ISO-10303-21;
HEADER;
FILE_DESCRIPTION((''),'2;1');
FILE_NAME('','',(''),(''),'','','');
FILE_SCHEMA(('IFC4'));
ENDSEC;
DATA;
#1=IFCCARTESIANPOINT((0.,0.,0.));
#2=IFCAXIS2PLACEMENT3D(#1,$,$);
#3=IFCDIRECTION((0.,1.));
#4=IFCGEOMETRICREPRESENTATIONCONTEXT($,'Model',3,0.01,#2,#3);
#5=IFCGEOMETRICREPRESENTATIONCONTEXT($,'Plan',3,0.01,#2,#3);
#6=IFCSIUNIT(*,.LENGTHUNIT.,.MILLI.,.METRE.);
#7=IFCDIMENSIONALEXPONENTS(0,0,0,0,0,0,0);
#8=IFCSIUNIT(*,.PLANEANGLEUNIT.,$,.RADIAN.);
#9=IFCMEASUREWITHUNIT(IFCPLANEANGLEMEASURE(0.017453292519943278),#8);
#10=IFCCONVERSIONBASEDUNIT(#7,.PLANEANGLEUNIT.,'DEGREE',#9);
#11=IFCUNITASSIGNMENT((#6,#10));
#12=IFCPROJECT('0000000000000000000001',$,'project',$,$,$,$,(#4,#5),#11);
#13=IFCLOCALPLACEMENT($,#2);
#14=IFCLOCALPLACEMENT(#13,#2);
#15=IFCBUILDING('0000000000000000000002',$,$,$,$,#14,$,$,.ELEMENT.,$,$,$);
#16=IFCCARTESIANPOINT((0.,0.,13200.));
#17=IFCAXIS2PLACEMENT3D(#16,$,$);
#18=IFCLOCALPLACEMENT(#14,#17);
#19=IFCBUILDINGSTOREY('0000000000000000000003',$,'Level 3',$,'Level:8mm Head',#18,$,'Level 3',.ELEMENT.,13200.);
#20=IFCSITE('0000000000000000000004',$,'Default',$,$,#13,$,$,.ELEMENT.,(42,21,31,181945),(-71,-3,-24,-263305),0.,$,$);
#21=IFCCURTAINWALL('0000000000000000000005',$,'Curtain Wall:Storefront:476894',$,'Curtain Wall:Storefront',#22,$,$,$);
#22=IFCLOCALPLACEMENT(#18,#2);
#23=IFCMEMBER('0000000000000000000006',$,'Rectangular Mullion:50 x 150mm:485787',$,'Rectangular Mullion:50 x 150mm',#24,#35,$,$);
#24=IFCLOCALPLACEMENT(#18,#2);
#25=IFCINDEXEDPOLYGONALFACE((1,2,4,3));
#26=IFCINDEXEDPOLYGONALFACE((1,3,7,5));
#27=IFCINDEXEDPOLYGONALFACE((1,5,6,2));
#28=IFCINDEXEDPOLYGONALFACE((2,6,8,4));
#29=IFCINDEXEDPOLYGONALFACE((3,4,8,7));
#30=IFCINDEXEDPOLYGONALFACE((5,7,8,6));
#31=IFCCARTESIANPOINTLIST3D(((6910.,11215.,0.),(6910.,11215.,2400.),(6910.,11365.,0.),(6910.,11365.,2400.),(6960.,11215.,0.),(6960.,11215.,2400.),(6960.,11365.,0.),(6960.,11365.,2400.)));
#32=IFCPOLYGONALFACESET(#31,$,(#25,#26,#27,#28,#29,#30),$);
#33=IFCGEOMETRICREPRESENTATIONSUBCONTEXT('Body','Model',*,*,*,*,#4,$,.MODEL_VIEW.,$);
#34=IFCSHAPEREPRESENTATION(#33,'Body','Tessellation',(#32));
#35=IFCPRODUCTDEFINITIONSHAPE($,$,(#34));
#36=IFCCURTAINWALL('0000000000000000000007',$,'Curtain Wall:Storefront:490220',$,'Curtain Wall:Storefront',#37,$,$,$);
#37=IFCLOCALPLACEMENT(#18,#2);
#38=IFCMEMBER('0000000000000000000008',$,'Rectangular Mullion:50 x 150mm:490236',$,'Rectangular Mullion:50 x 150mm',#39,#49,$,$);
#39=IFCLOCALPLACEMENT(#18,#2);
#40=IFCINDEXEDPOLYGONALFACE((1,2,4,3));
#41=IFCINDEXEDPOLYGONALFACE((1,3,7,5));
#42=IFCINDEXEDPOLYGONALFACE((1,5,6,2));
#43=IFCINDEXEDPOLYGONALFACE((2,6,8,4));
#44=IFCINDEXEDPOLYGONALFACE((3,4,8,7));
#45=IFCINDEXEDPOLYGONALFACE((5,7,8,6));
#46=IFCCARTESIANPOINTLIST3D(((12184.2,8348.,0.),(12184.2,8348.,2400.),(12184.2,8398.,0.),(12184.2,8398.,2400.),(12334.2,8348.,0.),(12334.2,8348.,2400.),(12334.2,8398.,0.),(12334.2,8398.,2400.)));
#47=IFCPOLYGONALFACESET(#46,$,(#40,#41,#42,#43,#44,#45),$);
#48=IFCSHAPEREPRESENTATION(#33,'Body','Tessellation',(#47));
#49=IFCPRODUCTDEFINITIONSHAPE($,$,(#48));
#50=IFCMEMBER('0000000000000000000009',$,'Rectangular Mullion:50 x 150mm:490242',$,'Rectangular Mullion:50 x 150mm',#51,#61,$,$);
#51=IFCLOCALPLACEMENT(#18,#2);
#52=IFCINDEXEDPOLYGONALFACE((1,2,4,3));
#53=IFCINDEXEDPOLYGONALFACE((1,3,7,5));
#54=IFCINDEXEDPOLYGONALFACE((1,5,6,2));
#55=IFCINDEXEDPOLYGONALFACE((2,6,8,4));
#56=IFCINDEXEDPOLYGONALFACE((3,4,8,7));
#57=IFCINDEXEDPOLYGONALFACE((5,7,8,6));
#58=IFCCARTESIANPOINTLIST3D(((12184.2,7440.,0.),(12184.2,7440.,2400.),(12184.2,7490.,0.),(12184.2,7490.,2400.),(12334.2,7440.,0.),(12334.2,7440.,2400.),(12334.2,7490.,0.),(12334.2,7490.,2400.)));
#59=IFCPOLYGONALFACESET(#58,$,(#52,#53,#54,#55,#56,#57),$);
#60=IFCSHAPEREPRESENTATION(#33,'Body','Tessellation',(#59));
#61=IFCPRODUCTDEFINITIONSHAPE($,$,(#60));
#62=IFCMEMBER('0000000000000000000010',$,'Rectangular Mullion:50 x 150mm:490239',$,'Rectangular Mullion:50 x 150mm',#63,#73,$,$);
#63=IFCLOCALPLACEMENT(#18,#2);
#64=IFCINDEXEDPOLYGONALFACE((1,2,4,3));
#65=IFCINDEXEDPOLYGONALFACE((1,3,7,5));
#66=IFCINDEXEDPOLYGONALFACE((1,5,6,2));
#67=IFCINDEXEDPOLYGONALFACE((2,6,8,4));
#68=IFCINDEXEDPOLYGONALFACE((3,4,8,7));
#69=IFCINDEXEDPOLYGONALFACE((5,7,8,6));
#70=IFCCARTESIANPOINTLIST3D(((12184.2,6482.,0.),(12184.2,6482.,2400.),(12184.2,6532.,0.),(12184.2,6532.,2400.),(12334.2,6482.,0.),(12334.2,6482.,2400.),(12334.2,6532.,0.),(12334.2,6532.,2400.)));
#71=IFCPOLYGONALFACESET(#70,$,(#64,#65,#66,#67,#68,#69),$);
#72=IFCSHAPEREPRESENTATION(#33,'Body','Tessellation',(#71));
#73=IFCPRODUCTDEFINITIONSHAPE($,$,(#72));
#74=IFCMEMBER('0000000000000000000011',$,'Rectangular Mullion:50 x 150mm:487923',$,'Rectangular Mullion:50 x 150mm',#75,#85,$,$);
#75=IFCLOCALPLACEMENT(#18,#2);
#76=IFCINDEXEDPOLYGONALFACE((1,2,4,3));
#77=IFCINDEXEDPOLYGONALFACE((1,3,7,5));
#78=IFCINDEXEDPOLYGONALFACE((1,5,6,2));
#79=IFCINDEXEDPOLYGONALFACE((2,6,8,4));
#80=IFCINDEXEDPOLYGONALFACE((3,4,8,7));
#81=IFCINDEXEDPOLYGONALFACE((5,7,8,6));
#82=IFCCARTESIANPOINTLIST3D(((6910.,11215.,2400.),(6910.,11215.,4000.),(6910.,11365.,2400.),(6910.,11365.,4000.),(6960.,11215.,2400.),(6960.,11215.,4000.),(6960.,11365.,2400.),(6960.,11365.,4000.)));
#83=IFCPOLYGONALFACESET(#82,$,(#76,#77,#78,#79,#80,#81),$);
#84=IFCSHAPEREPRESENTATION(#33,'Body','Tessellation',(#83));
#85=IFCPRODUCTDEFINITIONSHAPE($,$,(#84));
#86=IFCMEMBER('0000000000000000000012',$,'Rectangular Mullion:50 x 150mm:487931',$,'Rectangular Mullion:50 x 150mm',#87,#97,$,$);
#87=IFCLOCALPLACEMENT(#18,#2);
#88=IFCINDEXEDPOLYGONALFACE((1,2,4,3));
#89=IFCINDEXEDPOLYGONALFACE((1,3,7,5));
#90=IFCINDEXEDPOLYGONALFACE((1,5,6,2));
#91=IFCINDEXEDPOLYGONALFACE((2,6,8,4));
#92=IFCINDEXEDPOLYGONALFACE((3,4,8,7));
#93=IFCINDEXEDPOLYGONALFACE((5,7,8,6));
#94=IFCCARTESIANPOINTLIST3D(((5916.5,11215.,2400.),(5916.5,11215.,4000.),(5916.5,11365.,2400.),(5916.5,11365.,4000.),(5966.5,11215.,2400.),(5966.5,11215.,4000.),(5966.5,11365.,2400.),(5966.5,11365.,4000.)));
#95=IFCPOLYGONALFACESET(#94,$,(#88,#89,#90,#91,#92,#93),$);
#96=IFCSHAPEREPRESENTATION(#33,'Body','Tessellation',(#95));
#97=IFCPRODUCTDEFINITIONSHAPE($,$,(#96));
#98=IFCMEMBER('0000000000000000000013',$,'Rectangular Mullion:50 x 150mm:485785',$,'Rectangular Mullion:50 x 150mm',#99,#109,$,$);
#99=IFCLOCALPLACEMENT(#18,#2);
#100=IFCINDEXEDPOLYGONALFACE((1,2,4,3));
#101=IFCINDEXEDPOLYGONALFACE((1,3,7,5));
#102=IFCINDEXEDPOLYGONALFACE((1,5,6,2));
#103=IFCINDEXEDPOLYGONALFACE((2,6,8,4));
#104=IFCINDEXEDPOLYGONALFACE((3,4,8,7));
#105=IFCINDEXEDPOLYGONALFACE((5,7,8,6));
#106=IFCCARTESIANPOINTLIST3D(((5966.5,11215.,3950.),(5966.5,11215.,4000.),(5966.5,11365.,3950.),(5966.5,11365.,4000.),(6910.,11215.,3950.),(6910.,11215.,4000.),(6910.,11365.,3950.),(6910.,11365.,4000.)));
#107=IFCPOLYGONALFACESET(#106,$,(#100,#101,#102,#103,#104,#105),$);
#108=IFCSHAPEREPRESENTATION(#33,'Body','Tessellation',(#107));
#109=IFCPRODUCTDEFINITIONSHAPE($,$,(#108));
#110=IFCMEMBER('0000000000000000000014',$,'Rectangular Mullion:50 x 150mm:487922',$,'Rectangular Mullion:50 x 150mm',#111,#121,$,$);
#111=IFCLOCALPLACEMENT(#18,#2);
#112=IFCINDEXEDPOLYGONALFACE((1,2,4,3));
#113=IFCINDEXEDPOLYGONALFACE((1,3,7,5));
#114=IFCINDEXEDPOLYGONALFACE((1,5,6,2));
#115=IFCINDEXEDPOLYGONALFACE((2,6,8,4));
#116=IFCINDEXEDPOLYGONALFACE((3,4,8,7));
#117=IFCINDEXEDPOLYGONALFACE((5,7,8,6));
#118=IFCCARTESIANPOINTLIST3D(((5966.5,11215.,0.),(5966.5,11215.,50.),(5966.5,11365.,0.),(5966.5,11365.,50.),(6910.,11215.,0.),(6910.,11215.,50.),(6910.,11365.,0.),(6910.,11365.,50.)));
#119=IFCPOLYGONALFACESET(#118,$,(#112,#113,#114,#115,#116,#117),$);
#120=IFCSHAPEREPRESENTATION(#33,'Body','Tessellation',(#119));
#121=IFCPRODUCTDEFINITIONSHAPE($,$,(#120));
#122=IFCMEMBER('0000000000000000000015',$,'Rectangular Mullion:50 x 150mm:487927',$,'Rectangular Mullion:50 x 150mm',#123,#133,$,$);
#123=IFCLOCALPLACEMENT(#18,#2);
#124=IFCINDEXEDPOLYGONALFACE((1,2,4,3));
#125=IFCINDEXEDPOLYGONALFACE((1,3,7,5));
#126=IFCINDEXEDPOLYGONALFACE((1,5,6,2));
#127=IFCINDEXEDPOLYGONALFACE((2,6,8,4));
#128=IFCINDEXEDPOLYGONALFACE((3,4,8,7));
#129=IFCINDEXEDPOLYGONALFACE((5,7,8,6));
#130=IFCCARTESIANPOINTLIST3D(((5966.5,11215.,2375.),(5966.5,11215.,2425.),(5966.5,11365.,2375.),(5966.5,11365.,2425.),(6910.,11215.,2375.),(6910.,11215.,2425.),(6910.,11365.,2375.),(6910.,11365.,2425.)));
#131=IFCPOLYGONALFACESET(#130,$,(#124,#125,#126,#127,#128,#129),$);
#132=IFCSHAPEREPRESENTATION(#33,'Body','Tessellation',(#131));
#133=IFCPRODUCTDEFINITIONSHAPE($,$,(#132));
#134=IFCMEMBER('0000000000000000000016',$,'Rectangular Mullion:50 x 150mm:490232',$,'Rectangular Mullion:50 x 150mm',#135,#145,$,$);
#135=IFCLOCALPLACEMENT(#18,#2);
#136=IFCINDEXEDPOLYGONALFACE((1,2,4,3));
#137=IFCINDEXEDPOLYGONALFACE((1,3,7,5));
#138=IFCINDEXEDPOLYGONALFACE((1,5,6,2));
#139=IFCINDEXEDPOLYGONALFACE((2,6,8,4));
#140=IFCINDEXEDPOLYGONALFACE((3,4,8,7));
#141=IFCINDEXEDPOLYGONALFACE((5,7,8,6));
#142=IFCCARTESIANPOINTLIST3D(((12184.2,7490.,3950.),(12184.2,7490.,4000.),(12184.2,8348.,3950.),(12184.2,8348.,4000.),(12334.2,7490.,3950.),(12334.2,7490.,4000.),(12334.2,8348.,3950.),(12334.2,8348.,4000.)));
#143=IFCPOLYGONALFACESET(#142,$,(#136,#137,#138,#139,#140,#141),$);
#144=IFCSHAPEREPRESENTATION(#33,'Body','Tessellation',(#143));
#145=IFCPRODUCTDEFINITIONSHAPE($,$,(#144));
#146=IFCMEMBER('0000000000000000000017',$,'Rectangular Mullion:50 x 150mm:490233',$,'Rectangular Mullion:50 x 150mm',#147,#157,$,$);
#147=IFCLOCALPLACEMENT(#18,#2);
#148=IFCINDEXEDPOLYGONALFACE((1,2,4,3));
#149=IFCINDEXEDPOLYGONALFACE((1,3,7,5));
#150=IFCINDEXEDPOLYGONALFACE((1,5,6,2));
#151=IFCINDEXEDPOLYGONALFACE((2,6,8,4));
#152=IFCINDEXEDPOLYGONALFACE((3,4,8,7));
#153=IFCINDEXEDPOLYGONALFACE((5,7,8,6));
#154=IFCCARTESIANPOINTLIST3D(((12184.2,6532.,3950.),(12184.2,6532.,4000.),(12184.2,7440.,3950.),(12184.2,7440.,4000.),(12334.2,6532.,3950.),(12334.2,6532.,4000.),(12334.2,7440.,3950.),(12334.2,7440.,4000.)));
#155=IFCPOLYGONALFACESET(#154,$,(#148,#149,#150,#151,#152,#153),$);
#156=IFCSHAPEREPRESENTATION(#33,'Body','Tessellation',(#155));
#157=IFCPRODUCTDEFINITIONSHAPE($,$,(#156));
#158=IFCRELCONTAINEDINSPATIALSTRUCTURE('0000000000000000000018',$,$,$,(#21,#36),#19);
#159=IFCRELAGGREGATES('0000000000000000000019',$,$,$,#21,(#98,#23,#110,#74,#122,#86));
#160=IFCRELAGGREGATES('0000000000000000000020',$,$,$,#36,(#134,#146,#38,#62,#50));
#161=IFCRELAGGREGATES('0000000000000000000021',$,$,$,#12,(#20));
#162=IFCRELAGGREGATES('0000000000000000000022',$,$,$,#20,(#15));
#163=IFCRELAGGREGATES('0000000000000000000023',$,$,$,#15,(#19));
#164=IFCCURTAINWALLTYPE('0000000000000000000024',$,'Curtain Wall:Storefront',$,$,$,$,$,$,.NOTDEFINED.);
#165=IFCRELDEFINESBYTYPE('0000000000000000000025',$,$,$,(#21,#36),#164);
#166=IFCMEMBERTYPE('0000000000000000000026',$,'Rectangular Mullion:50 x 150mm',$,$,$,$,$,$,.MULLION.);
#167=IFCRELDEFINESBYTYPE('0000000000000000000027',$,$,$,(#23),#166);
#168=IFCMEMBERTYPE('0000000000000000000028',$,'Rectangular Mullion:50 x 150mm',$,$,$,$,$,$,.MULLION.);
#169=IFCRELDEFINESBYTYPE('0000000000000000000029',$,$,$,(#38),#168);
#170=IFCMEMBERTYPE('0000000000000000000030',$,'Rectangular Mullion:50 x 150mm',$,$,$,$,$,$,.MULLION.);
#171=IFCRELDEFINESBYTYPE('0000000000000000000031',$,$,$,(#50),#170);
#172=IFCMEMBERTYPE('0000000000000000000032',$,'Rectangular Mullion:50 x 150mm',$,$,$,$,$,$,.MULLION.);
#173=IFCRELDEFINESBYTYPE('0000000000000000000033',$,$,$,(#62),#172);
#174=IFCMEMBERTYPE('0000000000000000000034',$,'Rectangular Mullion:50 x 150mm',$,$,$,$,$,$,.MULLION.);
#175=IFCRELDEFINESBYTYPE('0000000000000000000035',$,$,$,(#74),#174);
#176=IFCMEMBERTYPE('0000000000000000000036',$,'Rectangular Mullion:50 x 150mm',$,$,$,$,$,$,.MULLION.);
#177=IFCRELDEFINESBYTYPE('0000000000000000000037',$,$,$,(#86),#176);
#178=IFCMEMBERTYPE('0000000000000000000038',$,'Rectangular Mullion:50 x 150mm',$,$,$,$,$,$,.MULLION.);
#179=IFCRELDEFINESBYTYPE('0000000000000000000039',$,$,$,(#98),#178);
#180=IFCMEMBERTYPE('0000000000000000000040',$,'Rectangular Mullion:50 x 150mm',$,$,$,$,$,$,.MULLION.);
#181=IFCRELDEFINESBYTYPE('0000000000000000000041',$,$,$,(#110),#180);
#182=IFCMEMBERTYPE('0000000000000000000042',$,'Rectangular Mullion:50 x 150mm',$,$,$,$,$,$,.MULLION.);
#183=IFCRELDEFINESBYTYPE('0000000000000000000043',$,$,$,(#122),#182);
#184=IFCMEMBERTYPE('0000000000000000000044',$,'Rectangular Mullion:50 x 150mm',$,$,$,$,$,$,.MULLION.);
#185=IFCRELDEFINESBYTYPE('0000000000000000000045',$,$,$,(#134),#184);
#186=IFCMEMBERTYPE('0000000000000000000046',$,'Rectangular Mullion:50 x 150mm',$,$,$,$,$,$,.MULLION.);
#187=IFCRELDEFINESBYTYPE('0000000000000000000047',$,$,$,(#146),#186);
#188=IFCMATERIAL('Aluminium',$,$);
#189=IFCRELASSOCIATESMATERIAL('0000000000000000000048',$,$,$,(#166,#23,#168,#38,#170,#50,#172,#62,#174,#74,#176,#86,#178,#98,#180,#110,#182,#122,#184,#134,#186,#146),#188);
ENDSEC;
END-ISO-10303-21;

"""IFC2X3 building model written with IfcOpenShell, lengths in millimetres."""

from ifc_helpers import new_model, entity, si_unit, converted_unit, direction, frame, origin, origin_2d_with_axis, place, context, subcontext, project, spatial, rectangle, extrude, source, transform, mapped, material, type_object, type_shapes, element, aggregate, save


model = new_model("IFC2X3")

# Units and contexts
model_context = context("Model", 3, precision=0.01, world=origin(), true_north=direction((0.0, 1.0)))
plan_context = context("Plan", 3, precision=0.01, world=origin(), true_north=direction((0.0, 1.0)))
body_context = subcontext(model_context, "Body", "Model", "MODEL_VIEW")
ifc_project = project(units=[si_unit("LENGTHUNIT", "METRE", prefix="MILLI"), converted_unit("PLANEANGLEUNIT", "DEGREE", entity("IfcPlaneAngleMeasure", 0.017453292519943278), si_unit("PLANEANGLEUNIT", "RADIAN"), dimensions=[0, 0, 0, 0, 0, 0, 0])], contexts=[model_context, plan_context])

# Site, building, storey
site_placement = place(None, origin())
site = spatial("IfcSite", under=ifc_project, at=site_placement, Name="Default", CompositionType="ELEMENT", RefLatitude=(42, 21, 31, 181945), RefLongitude=(-71, -3, -24, -263305), RefElevation=0.0)
building_placement = place(site_placement, origin())
building = spatial("IfcBuilding", under=site, at=building_placement, CompositionType="ELEMENT")
storey_placement = place(building_placement, frame((0.0, 0.0, 13200.0)))
storey = spatial("IfcBuildingStorey", under=building, at=storey_placement, Name="Level 3", ObjectType="Level:8mm Head", LongName="Level 3", CompositionType="ELEMENT", Elevation=13200.0)

# Curtain wall, member
curtain_wall_type = type_object("IfcCurtainWallType", Name="Curtain Wall:Storefront", PredefinedType="NOTDEFINED")
curtain_wall_1_placement = place(storey_placement, frame((0.0, 0.0, -13200.0)))
curtain_wall_1 = element("IfcCurtainWall", 1, at=curtain_wall_1_placement, inside=storey, type_object=curtain_wall_type, Name="Curtain Wall:Storefront:476894", ObjectType="Curtain Wall:Storefront")
ifc_material_1 = material(Name="Aluminium")
member_type_1 = type_object("IfcMemberType", Name="Rectangular Mullion:50 x 150mm", PredefinedType="MULLION", material=ifc_material_1)
shared_shape_1 = source(origin(), body_context, "Body", "SweptSolid", [
    extrude(rectangle(XDim=50.0, YDim=150.0, at=origin_2d_with_axis()), frame((-25.0, 0.0, -2400.0), z_axis=(0.0, 0.0, 1.0), x_axis=(-1.0, 0.0, 0.0)), (0.0, 0.0, 1.0), 2400.0),
])
type_shapes(member_type_1, [shared_shape_1])
member_1_placement = place(curtain_wall_1_placement, frame((6960.0, 11290.0, 13200.0), z_axis=(0.0, 0.0, -1.0), x_axis=(1.0, 0.0, 0.0)))
member_1 = element("IfcMember", 2, at=member_1_placement, type_object=member_type_1, material=ifc_material_1, Name="Rectangular Mullion:50 x 150mm:485787", ObjectType="Rectangular Mullion:50 x 150mm", context=body_context, shape_type="MappedRepresentation", body=[
    mapped(shared_shape_1, transform((0.0, 0.0, 0.0), scale=1.0)),
])

# Curtain wall, members
curtain_wall_2_placement = place(storey_placement, frame((0.0, 0.0, -13200.0)))
curtain_wall_2 = element("IfcCurtainWall", 3, at=curtain_wall_2_placement, inside=storey, type_object=curtain_wall_type, Name="Curtain Wall:Storefront:490220", ObjectType="Curtain Wall:Storefront")
member_type_2 = type_object("IfcMemberType", Name="Rectangular Mullion:50 x 150mm", PredefinedType="MULLION", material=ifc_material_1)
shared_shape_2 = source(origin(), body_context, "Body", "SweptSolid", [
    extrude(rectangle(XDim=50.0, YDim=150.0, at=origin_2d_with_axis()), frame((-25.0, 0.0, -2400.0), z_axis=(0.0, 0.0, 1.0), x_axis=(-1.0, 0.0, 0.0)), (0.0, 0.0, 1.0), 2400.0),
])
type_shapes(member_type_2, [shared_shape_2])
member_2_placement = place(curtain_wall_2_placement, frame((12259.2, 8398.0, 13200.0), z_axis=(0.0, 0.0, -1.0), x_axis=(0.0, 1.0, 0.0)))
member_2 = element("IfcMember", 4, at=member_2_placement, type_object=member_type_2, material=ifc_material_1, Name="Rectangular Mullion:50 x 150mm:490236", ObjectType="Rectangular Mullion:50 x 150mm", context=body_context, shape_type="MappedRepresentation", body=[
    mapped(shared_shape_2, transform((0.0, 0.0, 0.0), scale=1.0)),
])
member_type_3 = type_object("IfcMemberType", Name="Rectangular Mullion:50 x 150mm", PredefinedType="MULLION", material=ifc_material_1)
shared_shape_3 = source(origin(), body_context, "Body", "SweptSolid", [
    extrude(rectangle(XDim=50.0, YDim=150.0, at=origin_2d_with_axis()), frame((0.0, 0.0, -2400.0), z_axis=(0.0, 0.0, 1.0), x_axis=(-1.0, 0.0, 0.0)), (0.0, 0.0, 1.0), 2400.0),
])
type_shapes(member_type_3, [shared_shape_3])
member_3_placement = place(curtain_wall_2_placement, frame((12259.2, 7465.0, 13200.0), z_axis=(0.0, 0.0, -1.0), x_axis=(0.0, 1.0, 0.0)))
member_3 = element("IfcMember", 5, at=member_3_placement, type_object=member_type_3, material=ifc_material_1, Name="Rectangular Mullion:50 x 150mm:490242", ObjectType="Rectangular Mullion:50 x 150mm", context=body_context, shape_type="MappedRepresentation", body=[
    mapped(shared_shape_3, transform((0.0, 0.0, 0.0), scale=1.0)),
])
member_type_4 = type_object("IfcMemberType", Name="Rectangular Mullion:50 x 150mm", PredefinedType="MULLION", material=ifc_material_1)
shared_shape_4 = source(origin(), body_context, "Body", "SweptSolid", [
    extrude(rectangle(XDim=50.0, YDim=150.0, at=origin_2d_with_axis()), frame((-25.0, 0.0, -2400.0), z_axis=(0.0, 0.0, 1.0), x_axis=(-1.0, 0.0, 0.0)), (0.0, 0.0, 1.0), 2400.0),
])
type_shapes(member_type_4, [shared_shape_4])
member_4_placement = place(curtain_wall_2_placement, frame((12259.2, 6482.0, 15600.0), z_axis=(0.0, 0.0, 1.0), x_axis=(0.0, -1.0, 0.0)))
member_4 = element("IfcMember", 6, at=member_4_placement, type_object=member_type_4, material=ifc_material_1, Name="Rectangular Mullion:50 x 150mm:490239", ObjectType="Rectangular Mullion:50 x 150mm", context=body_context, shape_type="MappedRepresentation", body=[
    mapped(shared_shape_4, transform((0.0, 0.0, 0.0), scale=1.0)),
])

# Members
member_type_5 = type_object("IfcMemberType", Name="Rectangular Mullion:50 x 150mm", PredefinedType="MULLION", material=ifc_material_1)
shared_shape_5 = source(origin(), body_context, "Body", "SweptSolid", [
    extrude(rectangle(XDim=50.0, YDim=150.0, at=origin_2d_with_axis()), frame((-25.0, 0.0, -1600.0), z_axis=(0.0, 0.0, 1.0), x_axis=(-1.0, 0.0, 0.0)), (0.0, 0.0, 1.0), 1600.0),
])
type_shapes(member_type_5, [shared_shape_5])
member_5_placement = place(curtain_wall_1_placement, frame((6960.0, 11290.0, 15600.0), z_axis=(0.0, 0.0, -1.0), x_axis=(1.0, 0.0, 0.0)))
member_5 = element("IfcMember", 7, at=member_5_placement, type_object=member_type_5, material=ifc_material_1, Name="Rectangular Mullion:50 x 150mm:487923", ObjectType="Rectangular Mullion:50 x 150mm", context=body_context, shape_type="MappedRepresentation", body=[
    mapped(shared_shape_5, transform((0.0, 0.0, 0.0), scale=1.0)),
])
member_type_6 = type_object("IfcMemberType", Name="Rectangular Mullion:50 x 150mm", PredefinedType="MULLION", material=ifc_material_1)
shared_shape_6 = source(origin(), body_context, "Body", "SweptSolid", [
    extrude(rectangle(XDim=50.0, YDim=150.0, at=origin_2d_with_axis()), frame((0.0, 0.0, -1600.0), z_axis=(0.0, 0.0, 1.0), x_axis=(-1.0, 0.0, 0.0)), (0.0, 0.0, 1.0), 1600.0),
])
type_shapes(member_type_6, [shared_shape_6])
member_6_placement = place(curtain_wall_1_placement, frame((5941.5, 11290.0, 15600.0), z_axis=(0.0, 0.0, -1.0), x_axis=(1.0, 0.0, 0.0)))
member_6 = element("IfcMember", 8, at=member_6_placement, type_object=member_type_6, material=ifc_material_1, Name="Rectangular Mullion:50 x 150mm:487931", ObjectType="Rectangular Mullion:50 x 150mm", context=body_context, shape_type="MappedRepresentation", body=[
    mapped(shared_shape_6, transform((0.0, 0.0, 0.0), scale=1.0)),
])
member_type_7 = type_object("IfcMemberType", Name="Rectangular Mullion:50 x 150mm", PredefinedType="MULLION", material=ifc_material_1)
shared_shape_7 = source(origin(), body_context, "Body", "SweptSolid", [
    extrude(rectangle(XDim=50.0, YDim=150.0, at=origin_2d_with_axis()), frame((-25.0, 0.0, -943.5), z_axis=(0.0, 0.0, 1.0), x_axis=(-1.0, 0.0, 0.0)), (0.0, 0.0, 1.0), 943.5),
])
type_shapes(member_type_7, [shared_shape_7])
member_7_placement = place(curtain_wall_1_placement, frame((6910.0, 11290.0, 17200.0), z_axis=(1.0, 0.0, 0.0), x_axis=(0.0, 0.0, 1.0)))
member_7 = element("IfcMember", 9, at=member_7_placement, type_object=member_type_7, material=ifc_material_1, Name="Rectangular Mullion:50 x 150mm:485785", ObjectType="Rectangular Mullion:50 x 150mm", context=body_context, shape_type="MappedRepresentation", body=[
    mapped(shared_shape_7, transform((0.0, 0.0, 0.0), scale=1.0)),
])
member_type_8 = type_object("IfcMemberType", Name="Rectangular Mullion:50 x 150mm", PredefinedType="MULLION", material=ifc_material_1)
shared_shape_8 = source(origin(), body_context, "Body", "SweptSolid", [
    extrude(rectangle(XDim=50.0, YDim=150.0, at=origin_2d_with_axis()), frame((-25.0, 0.0, -943.5), z_axis=(0.0, 0.0, 1.0), x_axis=(-1.0, 0.0, 0.0)), (0.0, 0.0, 1.0), 943.5),
])
type_shapes(member_type_8, [shared_shape_8])
member_8_placement = place(curtain_wall_1_placement, frame((5966.5, 11290.0, 13200.0), z_axis=(-1.0, 0.0, 0.0), x_axis=(0.0, 0.0, -1.0)))
member_8 = element("IfcMember", 10, at=member_8_placement, type_object=member_type_8, material=ifc_material_1, Name="Rectangular Mullion:50 x 150mm:487922", ObjectType="Rectangular Mullion:50 x 150mm", context=body_context, shape_type="MappedRepresentation", body=[
    mapped(shared_shape_8, transform((0.0, 0.0, 0.0), scale=1.0)),
])
member_type_9 = type_object("IfcMemberType", Name="Rectangular Mullion:50 x 150mm", PredefinedType="MULLION", material=ifc_material_1)
shared_shape_9 = source(origin(), body_context, "Body", "SweptSolid", [
    extrude(rectangle(XDim=50.0, YDim=150.0, at=origin_2d_with_axis()), frame((0.0, 0.0, -943.5), z_axis=(0.0, 0.0, 1.0), x_axis=(-1.0, 0.0, 0.0)), (0.0, 0.0, 1.0), 943.5),
])
type_shapes(member_type_9, [shared_shape_9])
member_9_placement = place(curtain_wall_1_placement, frame((6910.0, 11290.0, 15600.0), z_axis=(1.0, 0.0, 0.0), x_axis=(0.0, 0.0, 1.0)))
member_9 = element("IfcMember", 11, at=member_9_placement, type_object=member_type_9, material=ifc_material_1, Name="Rectangular Mullion:50 x 150mm:487927", ObjectType="Rectangular Mullion:50 x 150mm", context=body_context, shape_type="MappedRepresentation", body=[
    mapped(shared_shape_9, transform((0.0, 0.0, 0.0), scale=1.0)),
])
member_type_10 = type_object("IfcMemberType", Name="Rectangular Mullion:50 x 150mm", PredefinedType="MULLION", material=ifc_material_1)
shared_shape_10 = source(origin(), body_context, "Body", "SweptSolid", [
    extrude(rectangle(XDim=50.0, YDim=150.0, at=origin_2d_with_axis()), frame((-25.0, 0.0, -858.0), z_axis=(0.0, 0.0, 1.0), x_axis=(-1.0, 0.0, 0.0)), (0.0, 0.0, 1.0), 858.0),
])
type_shapes(member_type_10, [shared_shape_10])
member_10_placement = place(curtain_wall_2_placement, frame((12259.2, 8348.0, 17200.0), z_axis=(0.0, 1.0, 0.0), x_axis=(0.0, 0.0, 1.0)))
member_10 = element("IfcMember", 12, at=member_10_placement, type_object=member_type_10, material=ifc_material_1, Name="Rectangular Mullion:50 x 150mm:490232", ObjectType="Rectangular Mullion:50 x 150mm", context=body_context, shape_type="MappedRepresentation", body=[
    mapped(shared_shape_10, transform((0.0, 0.0, 0.0), scale=1.0)),
])
member_type_11 = type_object("IfcMemberType", Name="Rectangular Mullion:50 x 150mm", PredefinedType="MULLION", material=ifc_material_1)
shared_shape_11 = source(origin(), body_context, "Body", "SweptSolid", [
    extrude(rectangle(XDim=50.0, YDim=150.0, at=origin_2d_with_axis()), frame((-25.0, 0.0, -908.0), z_axis=(0.0, 0.0, 1.0), x_axis=(-1.0, 0.0, 0.0)), (0.0, 0.0, 1.0), 908.0),
])
type_shapes(member_type_11, [shared_shape_11])
member_11_placement = place(curtain_wall_2_placement, frame((12259.2, 7440.0, 17200.0), z_axis=(0.0, 1.0, 0.0), x_axis=(0.0, 0.0, 1.0)))
member_11 = element("IfcMember", 13, at=member_11_placement, type_object=member_type_11, material=ifc_material_1, Name="Rectangular Mullion:50 x 150mm:490233", ObjectType="Rectangular Mullion:50 x 150mm", context=body_context, shape_type="MappedRepresentation", body=[
    mapped(shared_shape_11, transform((0.0, 0.0, 0.0), scale=1.0)),
])

aggregate(curtain_wall_1, [member_7, member_1, member_8, member_5, member_9, member_6])

aggregate(curtain_wall_2, [member_10, member_11, member_2, member_4, member_3])

save(model, "model.ifc")
